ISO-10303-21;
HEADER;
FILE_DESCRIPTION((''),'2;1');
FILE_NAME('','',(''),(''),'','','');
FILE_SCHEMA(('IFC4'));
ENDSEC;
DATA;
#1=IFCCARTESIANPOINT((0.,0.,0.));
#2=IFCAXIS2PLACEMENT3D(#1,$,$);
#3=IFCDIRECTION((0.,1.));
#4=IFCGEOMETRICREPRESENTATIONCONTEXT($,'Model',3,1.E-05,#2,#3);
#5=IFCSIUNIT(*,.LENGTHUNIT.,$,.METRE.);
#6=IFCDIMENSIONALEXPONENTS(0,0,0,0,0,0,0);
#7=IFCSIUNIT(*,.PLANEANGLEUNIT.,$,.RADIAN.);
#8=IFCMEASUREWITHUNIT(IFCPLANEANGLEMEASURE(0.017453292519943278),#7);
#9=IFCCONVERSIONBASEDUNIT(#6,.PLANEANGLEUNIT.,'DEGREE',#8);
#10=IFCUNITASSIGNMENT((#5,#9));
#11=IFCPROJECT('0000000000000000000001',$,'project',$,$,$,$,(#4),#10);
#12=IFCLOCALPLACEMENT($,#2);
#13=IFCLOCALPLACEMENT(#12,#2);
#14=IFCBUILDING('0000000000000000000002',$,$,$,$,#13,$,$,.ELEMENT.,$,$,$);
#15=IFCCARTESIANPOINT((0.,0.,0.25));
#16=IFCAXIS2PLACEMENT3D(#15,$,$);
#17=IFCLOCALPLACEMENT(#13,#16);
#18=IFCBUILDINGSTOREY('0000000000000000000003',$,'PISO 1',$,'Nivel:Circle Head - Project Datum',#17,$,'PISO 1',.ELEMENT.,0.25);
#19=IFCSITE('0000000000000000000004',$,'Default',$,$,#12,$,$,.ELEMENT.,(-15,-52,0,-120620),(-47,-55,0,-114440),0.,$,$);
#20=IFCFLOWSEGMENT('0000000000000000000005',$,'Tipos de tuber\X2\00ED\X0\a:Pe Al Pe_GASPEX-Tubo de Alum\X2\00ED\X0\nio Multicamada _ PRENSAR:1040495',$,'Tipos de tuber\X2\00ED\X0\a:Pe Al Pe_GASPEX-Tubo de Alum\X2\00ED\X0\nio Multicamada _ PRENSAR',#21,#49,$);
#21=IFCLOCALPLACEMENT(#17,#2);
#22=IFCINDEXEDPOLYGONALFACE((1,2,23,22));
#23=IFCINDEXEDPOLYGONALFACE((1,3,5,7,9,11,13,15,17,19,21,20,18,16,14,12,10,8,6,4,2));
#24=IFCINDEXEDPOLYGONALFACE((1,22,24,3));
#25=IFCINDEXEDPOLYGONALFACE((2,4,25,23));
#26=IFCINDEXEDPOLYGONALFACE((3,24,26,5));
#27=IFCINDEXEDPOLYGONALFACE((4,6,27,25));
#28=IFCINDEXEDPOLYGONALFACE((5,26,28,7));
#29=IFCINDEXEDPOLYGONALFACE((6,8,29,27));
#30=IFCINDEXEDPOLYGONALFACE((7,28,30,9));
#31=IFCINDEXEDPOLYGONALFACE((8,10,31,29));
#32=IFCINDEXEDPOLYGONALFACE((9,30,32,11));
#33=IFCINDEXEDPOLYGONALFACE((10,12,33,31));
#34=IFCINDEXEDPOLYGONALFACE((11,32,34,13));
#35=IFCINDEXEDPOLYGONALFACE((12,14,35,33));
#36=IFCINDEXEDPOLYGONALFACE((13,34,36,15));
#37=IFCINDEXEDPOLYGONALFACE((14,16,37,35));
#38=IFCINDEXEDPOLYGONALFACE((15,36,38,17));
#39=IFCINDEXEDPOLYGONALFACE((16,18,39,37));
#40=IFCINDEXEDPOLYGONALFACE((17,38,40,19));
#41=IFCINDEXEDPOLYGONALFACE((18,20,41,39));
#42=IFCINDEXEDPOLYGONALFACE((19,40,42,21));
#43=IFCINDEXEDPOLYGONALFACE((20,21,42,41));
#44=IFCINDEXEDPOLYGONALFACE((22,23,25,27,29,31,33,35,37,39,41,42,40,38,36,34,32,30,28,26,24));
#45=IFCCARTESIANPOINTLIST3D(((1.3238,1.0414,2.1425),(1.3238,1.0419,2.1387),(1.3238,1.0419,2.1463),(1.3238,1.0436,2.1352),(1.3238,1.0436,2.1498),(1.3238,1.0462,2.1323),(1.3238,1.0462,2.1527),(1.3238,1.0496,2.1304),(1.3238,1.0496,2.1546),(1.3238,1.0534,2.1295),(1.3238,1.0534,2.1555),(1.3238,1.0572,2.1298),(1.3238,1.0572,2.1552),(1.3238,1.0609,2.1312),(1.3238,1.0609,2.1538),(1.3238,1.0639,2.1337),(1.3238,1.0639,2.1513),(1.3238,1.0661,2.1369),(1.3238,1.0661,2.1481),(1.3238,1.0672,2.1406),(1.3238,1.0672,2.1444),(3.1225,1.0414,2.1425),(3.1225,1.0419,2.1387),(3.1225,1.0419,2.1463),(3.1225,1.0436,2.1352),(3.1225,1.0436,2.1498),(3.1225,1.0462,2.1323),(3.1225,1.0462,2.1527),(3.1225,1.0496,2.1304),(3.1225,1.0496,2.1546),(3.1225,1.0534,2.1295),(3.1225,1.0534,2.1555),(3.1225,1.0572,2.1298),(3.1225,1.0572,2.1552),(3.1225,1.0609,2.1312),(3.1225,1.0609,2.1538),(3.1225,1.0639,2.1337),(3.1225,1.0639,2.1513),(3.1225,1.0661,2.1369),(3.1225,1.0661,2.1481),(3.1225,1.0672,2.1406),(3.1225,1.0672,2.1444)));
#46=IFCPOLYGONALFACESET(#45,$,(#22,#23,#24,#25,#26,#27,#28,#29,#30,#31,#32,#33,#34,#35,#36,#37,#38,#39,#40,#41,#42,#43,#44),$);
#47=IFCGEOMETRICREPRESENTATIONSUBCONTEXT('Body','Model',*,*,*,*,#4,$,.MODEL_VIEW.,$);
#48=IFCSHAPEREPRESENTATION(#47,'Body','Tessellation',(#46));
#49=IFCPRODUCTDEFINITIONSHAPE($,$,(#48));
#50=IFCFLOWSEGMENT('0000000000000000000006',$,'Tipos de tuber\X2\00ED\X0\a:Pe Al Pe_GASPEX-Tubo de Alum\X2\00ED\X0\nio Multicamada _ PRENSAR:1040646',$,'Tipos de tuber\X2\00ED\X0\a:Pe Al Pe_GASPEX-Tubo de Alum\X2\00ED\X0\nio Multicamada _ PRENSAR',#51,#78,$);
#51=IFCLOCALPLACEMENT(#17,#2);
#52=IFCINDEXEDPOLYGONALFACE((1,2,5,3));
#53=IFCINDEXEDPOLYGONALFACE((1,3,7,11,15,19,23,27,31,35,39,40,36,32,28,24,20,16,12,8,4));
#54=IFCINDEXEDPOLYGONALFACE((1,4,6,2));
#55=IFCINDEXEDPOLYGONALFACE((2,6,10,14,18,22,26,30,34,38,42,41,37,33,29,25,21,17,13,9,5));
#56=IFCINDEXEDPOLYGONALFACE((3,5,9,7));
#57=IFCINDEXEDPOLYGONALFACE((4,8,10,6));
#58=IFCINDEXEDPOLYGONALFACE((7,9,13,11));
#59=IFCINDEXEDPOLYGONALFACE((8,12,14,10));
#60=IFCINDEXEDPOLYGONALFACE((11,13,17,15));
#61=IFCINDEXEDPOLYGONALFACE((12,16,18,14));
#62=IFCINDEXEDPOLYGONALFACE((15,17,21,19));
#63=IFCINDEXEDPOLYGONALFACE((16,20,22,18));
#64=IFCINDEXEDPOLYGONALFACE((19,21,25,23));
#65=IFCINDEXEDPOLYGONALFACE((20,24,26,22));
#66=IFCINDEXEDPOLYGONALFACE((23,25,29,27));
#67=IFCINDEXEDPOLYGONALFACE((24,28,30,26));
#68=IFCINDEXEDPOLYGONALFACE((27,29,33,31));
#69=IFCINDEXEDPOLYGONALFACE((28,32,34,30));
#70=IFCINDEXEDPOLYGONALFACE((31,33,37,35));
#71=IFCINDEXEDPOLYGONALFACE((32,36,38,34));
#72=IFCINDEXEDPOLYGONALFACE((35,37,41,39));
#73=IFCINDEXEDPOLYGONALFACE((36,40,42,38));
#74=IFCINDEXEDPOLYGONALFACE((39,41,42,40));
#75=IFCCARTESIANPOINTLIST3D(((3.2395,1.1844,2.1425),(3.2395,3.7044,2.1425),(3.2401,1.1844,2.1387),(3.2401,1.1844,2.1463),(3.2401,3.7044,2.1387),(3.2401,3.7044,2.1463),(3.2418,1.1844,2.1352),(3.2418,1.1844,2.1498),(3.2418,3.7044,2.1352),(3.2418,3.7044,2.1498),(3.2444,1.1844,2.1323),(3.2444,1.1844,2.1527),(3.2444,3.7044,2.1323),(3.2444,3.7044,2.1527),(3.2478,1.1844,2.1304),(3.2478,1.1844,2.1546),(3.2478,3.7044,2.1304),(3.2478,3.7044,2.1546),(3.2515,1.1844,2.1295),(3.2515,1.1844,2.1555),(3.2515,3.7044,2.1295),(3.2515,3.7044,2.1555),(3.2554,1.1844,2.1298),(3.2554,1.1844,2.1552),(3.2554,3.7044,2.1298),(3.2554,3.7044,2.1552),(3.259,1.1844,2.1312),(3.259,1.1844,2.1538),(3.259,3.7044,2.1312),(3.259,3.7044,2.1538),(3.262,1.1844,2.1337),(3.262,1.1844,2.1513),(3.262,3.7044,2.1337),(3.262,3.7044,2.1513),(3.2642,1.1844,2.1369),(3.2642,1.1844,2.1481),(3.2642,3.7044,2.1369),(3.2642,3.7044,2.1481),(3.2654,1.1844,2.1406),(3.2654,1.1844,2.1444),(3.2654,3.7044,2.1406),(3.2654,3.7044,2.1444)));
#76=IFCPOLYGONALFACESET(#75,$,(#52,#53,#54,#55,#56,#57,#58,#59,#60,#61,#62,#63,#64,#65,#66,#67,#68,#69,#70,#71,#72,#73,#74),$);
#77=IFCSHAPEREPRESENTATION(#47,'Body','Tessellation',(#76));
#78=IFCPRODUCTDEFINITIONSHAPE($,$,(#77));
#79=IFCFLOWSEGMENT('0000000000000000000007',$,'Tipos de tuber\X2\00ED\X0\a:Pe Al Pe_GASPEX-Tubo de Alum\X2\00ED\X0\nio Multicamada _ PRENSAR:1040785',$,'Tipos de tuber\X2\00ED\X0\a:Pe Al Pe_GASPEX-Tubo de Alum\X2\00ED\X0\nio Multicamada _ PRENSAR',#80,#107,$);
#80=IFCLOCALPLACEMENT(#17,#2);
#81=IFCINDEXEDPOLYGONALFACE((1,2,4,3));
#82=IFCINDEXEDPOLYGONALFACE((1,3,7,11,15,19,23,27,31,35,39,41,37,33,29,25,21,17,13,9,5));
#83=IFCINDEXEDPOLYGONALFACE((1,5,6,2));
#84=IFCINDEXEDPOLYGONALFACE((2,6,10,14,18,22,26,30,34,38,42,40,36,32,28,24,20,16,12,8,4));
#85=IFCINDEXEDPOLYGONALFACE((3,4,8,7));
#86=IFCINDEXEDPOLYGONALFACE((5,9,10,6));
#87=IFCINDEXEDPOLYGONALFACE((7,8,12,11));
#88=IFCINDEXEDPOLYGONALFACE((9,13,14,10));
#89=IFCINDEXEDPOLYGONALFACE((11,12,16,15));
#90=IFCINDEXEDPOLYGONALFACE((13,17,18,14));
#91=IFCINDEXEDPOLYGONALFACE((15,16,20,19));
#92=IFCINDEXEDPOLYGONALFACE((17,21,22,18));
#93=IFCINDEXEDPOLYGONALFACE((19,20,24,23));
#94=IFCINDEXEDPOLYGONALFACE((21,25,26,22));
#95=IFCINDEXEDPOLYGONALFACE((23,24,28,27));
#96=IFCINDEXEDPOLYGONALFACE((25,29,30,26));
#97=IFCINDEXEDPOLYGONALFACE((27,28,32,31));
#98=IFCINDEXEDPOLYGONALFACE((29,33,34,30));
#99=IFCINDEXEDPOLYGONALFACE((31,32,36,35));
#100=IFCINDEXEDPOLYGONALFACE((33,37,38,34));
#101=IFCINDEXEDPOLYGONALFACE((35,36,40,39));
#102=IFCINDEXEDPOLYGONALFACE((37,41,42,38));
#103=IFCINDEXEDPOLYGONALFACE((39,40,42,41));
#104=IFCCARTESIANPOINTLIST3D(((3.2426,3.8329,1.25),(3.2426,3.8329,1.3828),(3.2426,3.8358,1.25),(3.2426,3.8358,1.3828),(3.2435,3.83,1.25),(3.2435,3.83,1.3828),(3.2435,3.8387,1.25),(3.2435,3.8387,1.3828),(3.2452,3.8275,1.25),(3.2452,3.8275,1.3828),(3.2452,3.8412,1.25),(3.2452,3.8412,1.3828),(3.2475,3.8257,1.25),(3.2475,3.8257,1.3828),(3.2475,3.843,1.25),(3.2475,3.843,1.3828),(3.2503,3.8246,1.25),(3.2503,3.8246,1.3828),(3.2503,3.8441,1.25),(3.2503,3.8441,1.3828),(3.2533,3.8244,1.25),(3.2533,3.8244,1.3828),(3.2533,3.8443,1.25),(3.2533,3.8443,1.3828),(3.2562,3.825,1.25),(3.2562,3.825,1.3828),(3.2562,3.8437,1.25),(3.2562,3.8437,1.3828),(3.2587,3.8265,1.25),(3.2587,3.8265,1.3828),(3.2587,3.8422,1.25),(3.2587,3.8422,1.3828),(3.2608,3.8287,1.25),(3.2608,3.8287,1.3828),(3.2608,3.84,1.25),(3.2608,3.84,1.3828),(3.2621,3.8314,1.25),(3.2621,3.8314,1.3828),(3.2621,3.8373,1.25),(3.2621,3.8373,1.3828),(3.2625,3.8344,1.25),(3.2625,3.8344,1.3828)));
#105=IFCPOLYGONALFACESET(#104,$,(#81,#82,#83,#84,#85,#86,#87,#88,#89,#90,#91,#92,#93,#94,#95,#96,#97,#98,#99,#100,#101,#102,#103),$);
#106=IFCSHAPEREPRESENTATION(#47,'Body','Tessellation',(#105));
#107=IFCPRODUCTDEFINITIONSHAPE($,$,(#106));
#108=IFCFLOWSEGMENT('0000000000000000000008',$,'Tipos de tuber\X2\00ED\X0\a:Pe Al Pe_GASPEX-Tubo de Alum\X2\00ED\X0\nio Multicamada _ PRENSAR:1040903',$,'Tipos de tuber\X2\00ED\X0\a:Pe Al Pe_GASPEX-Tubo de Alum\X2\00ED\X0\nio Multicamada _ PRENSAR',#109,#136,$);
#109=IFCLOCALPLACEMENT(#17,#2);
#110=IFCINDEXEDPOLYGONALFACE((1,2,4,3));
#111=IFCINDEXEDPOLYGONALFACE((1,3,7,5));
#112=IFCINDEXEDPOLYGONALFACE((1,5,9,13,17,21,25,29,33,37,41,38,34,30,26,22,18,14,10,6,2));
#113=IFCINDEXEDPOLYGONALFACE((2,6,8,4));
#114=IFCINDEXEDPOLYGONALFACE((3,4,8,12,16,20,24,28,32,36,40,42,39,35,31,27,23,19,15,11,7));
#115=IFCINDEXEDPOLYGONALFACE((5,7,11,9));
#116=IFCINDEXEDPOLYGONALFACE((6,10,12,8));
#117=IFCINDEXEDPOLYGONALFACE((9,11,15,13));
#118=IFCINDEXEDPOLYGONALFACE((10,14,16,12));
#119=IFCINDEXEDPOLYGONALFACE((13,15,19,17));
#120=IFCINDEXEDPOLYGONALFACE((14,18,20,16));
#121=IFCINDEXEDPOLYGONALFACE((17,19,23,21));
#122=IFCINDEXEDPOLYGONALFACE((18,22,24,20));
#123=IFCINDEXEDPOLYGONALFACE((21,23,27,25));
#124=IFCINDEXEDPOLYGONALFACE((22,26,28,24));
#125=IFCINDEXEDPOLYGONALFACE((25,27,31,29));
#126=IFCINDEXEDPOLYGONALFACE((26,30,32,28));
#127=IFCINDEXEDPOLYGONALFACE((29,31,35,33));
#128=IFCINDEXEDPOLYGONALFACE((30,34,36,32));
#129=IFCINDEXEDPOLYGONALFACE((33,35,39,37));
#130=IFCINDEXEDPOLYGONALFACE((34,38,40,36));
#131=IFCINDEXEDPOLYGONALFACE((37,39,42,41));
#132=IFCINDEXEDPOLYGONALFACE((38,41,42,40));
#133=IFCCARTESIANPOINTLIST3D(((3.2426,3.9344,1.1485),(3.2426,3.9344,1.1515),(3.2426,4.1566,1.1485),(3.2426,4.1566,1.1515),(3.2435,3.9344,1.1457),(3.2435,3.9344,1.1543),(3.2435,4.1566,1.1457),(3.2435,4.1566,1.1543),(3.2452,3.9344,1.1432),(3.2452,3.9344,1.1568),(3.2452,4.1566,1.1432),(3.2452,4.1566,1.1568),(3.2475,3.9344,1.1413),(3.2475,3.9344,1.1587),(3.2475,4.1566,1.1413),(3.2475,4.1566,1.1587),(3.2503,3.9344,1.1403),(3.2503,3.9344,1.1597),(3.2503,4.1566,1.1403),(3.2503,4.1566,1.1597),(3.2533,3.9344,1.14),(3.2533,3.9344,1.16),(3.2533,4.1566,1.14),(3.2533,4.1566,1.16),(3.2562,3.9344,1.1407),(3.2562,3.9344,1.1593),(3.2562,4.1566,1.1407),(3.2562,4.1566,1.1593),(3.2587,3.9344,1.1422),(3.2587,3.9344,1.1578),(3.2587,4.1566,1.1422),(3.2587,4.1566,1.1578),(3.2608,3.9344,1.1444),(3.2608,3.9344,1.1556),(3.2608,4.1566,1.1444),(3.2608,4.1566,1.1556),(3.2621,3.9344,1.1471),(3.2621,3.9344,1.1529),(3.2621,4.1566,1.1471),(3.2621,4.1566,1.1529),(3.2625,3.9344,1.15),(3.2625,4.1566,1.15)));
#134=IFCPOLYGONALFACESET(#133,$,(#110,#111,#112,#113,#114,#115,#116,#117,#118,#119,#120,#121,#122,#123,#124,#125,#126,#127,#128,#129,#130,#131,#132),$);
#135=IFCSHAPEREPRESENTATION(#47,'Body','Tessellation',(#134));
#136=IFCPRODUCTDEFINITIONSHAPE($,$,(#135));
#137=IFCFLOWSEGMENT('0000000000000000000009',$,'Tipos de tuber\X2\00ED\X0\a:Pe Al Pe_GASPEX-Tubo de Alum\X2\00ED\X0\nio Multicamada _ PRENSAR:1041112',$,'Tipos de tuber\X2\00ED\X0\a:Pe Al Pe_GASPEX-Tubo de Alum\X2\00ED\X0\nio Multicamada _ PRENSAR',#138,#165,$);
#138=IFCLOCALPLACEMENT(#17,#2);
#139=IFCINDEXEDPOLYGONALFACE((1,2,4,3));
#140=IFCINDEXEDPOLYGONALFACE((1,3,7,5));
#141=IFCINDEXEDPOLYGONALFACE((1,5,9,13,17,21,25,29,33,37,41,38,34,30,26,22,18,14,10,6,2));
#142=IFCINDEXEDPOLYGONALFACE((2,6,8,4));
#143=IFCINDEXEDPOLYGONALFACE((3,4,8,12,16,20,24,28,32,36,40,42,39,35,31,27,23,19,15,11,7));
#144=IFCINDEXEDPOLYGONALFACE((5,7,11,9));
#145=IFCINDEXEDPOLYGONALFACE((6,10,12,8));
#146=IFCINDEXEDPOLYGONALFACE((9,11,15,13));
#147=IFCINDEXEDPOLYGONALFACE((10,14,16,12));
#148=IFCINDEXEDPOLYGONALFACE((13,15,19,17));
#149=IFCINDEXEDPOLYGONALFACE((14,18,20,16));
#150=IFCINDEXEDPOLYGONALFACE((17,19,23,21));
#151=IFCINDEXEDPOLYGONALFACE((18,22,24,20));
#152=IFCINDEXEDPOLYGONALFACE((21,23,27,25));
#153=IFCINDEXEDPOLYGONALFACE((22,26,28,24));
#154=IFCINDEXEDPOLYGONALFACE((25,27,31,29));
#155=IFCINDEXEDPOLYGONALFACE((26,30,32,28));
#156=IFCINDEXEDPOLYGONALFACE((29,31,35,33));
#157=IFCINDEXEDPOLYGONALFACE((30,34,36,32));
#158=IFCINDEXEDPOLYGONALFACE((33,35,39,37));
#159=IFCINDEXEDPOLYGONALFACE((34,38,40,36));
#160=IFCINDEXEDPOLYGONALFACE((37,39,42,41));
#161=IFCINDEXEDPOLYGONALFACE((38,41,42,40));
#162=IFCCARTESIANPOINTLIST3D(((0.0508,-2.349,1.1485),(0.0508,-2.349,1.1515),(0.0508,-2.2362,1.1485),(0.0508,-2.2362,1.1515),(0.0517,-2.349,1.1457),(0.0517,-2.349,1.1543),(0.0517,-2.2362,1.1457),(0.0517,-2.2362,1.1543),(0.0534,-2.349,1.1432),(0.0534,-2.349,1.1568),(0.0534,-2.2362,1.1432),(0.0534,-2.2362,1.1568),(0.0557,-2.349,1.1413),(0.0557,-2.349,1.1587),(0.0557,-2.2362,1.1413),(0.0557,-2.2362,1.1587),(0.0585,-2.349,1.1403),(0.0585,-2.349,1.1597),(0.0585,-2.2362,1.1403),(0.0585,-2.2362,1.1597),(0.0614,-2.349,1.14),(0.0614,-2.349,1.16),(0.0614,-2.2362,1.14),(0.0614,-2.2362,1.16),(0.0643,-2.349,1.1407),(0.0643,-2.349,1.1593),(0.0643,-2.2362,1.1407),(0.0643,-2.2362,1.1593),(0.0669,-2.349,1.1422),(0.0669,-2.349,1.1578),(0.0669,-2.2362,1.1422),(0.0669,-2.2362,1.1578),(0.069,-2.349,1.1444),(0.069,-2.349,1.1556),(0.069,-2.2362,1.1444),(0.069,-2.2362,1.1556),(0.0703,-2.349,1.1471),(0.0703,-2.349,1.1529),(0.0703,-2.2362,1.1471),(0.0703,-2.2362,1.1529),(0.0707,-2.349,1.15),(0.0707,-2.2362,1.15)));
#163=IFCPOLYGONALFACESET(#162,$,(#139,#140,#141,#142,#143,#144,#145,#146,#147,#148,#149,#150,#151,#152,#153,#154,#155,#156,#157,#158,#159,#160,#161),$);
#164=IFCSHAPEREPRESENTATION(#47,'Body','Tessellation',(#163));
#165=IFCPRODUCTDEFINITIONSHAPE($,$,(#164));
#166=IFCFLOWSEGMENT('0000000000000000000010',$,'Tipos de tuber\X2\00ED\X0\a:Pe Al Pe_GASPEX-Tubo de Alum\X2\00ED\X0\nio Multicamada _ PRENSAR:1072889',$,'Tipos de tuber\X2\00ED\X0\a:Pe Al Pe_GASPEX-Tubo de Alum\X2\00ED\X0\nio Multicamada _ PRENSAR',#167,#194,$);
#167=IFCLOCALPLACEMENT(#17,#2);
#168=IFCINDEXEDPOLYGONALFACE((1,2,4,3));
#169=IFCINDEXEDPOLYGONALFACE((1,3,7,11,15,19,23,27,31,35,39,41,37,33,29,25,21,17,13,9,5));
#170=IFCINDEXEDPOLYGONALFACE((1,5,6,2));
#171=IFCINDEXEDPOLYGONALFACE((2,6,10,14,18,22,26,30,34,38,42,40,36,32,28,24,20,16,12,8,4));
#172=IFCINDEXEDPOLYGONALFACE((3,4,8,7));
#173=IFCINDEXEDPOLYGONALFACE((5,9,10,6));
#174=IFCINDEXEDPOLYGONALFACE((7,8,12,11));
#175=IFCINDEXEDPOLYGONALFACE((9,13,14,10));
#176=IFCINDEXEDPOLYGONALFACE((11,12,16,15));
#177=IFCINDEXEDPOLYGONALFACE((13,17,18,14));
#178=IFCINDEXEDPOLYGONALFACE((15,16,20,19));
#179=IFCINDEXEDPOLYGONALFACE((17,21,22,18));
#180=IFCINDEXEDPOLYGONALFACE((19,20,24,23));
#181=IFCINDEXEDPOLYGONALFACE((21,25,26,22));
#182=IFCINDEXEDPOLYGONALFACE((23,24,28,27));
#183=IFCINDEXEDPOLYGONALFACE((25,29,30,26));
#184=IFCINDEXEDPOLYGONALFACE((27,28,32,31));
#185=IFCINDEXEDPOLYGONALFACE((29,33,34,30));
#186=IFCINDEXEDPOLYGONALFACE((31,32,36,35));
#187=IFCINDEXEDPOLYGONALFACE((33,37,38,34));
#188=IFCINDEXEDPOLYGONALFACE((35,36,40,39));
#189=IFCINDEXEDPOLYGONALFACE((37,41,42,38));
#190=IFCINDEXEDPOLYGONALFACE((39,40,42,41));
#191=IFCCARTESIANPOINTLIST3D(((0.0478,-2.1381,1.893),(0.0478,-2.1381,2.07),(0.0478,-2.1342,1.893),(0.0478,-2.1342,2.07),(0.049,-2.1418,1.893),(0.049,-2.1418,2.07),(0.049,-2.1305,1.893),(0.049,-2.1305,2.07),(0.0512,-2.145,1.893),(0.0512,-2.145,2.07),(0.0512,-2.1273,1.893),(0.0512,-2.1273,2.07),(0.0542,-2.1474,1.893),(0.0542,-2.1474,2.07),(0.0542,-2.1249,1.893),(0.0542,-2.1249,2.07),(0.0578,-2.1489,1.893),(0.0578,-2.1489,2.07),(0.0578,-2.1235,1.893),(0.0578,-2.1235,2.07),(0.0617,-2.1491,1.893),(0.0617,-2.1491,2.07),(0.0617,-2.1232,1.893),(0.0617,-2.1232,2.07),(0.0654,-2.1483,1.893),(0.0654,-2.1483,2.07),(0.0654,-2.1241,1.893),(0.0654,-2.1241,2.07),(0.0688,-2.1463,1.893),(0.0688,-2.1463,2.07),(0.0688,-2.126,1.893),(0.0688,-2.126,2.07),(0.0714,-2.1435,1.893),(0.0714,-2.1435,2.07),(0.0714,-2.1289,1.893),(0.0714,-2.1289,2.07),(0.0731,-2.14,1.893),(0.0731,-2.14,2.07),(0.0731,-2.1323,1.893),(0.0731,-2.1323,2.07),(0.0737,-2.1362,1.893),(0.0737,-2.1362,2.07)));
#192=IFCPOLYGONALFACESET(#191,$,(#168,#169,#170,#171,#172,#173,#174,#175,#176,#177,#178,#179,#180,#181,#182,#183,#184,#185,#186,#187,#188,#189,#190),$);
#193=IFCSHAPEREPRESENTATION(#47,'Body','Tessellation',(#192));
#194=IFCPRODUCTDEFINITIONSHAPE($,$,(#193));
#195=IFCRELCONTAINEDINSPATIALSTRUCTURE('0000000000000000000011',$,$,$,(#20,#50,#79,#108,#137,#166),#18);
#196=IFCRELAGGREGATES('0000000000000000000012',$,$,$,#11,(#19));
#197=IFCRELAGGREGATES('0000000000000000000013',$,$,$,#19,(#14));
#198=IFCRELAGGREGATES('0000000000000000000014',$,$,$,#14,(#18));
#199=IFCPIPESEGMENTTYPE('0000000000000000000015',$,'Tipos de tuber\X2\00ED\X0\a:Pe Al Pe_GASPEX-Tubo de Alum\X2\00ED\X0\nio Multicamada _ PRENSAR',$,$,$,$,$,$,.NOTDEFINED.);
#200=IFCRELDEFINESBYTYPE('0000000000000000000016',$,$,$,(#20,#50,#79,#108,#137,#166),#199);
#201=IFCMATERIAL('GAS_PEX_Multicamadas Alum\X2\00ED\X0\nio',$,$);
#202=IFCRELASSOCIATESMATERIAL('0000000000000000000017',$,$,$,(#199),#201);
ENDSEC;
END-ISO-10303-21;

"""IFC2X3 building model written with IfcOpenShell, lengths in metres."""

from ifc_helpers import new_model, entity, si_unit, converted_unit, direction, frame, frame_2d, origin, origin_2d_with_axis, place, context, subcontext, project, spatial, circle, extrude, material, type_object, element, save


model = new_model("IFC2X3")

# Units and contexts
model_context = context("Model", 3, precision=1e-05, world=origin(), true_north=direction((0.0, 1.0)))
body_context = subcontext(model_context, "Body", "Model", "MODEL_VIEW")
ifc_project = project(units=[si_unit("LENGTHUNIT", "METRE"), converted_unit("PLANEANGLEUNIT", "DEGREE", entity("IfcPlaneAngleMeasure", 0.017453292519943278), si_unit("PLANEANGLEUNIT", "RADIAN"), dimensions=[0, 0, 0, 0, 0, 0, 0])], contexts=[model_context])

# Site, building, storey
site_placement = place(None, origin())
site = spatial("IfcSite", under=ifc_project, at=site_placement, Name="Default", CompositionType="ELEMENT", RefLatitude=(-15, -52, 0, -120620), RefLongitude=(-47, -55, 0, -114440), RefElevation=0.0)
building_placement = place(site_placement, origin())
building = spatial("IfcBuilding", under=site, at=building_placement, CompositionType="ELEMENT")
storey_placement = place(building_placement, frame((0.0, 0.0, 0.25)))
storey = spatial("IfcBuildingStorey", under=building, at=storey_placement, Name="PISO 1", ObjectType="Nivel:Circle Head - Project Datum", LongName="PISO 1", CompositionType="ELEMENT", Elevation=0.25)

# Flow segments
ifc_material = material(Name="GAS_PEX_Multicamadas Alumínio")
pipe_segment_type = type_object("IfcPipeSegmentType", Name="Tipos de tubería:Pe Al Pe_GASPEX-Tubo de Alumínio Multicamada _ PRENSAR", PredefinedType="NOTDEFINED", material=ifc_material)
flow_segment_1_placement = place(storey_placement, origin())
element("IfcFlowSegment", 1, at=flow_segment_1_placement, inside=storey, type_object=pipe_segment_type, Name="Tipos de tubería:Pe Al Pe_GASPEX-Tubo de Alumínio Multicamada _ PRENSAR:1040495", ObjectType="Tipos de tubería:Pe Al Pe_GASPEX-Tubo de Alumínio Multicamada _ PRENSAR", context=body_context, shape_type="SweptSolid", body=[
    extrude(circle(Radius=0.013, at=origin_2d_with_axis()), frame((1.3238, 1.0544, 2.1425), z_axis=(1.0, 0.0, 0.0), x_axis=(0.0, -1.0, 0.0)), (0.0, 0.0, 1.0), 1.7987),
])
flow_segment_2_placement = place(storey_placement, origin())
element("IfcFlowSegment", 2, at=flow_segment_2_placement, inside=storey, type_object=pipe_segment_type, Name="Tipos de tubería:Pe Al Pe_GASPEX-Tubo de Alumínio Multicamada _ PRENSAR:1040646", ObjectType="Tipos de tubería:Pe Al Pe_GASPEX-Tubo de Alumínio Multicamada _ PRENSAR", context=body_context, shape_type="SweptSolid", body=[
    extrude(circle(Radius=0.013, at=origin_2d_with_axis()), frame((3.2525, 1.1844, 2.1425), z_axis=(0.0, 1.0, 0.0), x_axis=(-1.0, 0.0, 0.0)), (0.0, 0.0, 1.0), 2.52),
])
flow_segment_3_placement = place(storey_placement, origin())
element("IfcFlowSegment", 3, at=flow_segment_3_placement, inside=storey, type_object=pipe_segment_type, Name="Tipos de tubería:Pe Al Pe_GASPEX-Tubo de Alumínio Multicamada _ PRENSAR:1040785", ObjectType="Tipos de tubería:Pe Al Pe_GASPEX-Tubo de Alumínio Multicamada _ PRENSAR", context=body_context, shape_type="SweptSolid", body=[
    extrude(circle(Radius=0.01, at=origin_2d_with_axis()), frame((3.2525, 3.8344, 1.25)), (0.0, 0.0, 1.0), 0.1329),
])
flow_segment_4_placement = place(storey_placement, origin())
element("IfcFlowSegment", 4, at=flow_segment_4_placement, inside=storey, type_object=pipe_segment_type, Name="Tipos de tubería:Pe Al Pe_GASPEX-Tubo de Alumínio Multicamada _ PRENSAR:1040903", ObjectType="Tipos de tubería:Pe Al Pe_GASPEX-Tubo de Alumínio Multicamada _ PRENSAR", context=body_context, shape_type="SweptSolid", body=[
    extrude(circle(Radius=0.01, at=origin_2d_with_axis()), frame((3.2525, 3.9344, 1.15), z_axis=(0.0, 1.0, 0.0), x_axis=(1.0, 0.0, 0.0)), (0.0, 0.0, 1.0), 0.2223),
])
flow_segment_5_placement = place(storey_placement, origin())
element("IfcFlowSegment", 5, at=flow_segment_5_placement, inside=storey, type_object=pipe_segment_type, Name="Tipos de tubería:Pe Al Pe_GASPEX-Tubo de Alumínio Multicamada _ PRENSAR:1041112", ObjectType="Tipos de tubería:Pe Al Pe_GASPEX-Tubo de Alumínio Multicamada _ PRENSAR", context=body_context, shape_type="SweptSolid", body=[
    extrude(circle(Radius=0.01, at=frame_2d((0.0, 0.0), x_axis=(1.0, 0.0))), frame((0.0607, -2.349, 1.15), z_axis=(0.0, 1.0, 0.0), x_axis=(1.0, 0.0, 0.0)), (0.0, 0.0, 1.0), 0.1128),
])
flow_segment_6_placement = place(storey_placement, origin())
element("IfcFlowSegment", 6, at=flow_segment_6_placement, inside=storey, type_object=pipe_segment_type, Name="Tipos de tubería:Pe Al Pe_GASPEX-Tubo de Alumínio Multicamada _ PRENSAR:1072889", ObjectType="Tipos de tubería:Pe Al Pe_GASPEX-Tubo de Alumínio Multicamada _ PRENSAR", context=body_context, shape_type="SweptSolid", body=[
    extrude(circle(Radius=0.013, at=frame_2d((0.0, 0.0), x_axis=(1.0, 0.0))), frame((0.0607, -2.1362, 1.893)), (0.0, 0.0, 1.0), 0.177),
])

save(model, "model.ifc")
